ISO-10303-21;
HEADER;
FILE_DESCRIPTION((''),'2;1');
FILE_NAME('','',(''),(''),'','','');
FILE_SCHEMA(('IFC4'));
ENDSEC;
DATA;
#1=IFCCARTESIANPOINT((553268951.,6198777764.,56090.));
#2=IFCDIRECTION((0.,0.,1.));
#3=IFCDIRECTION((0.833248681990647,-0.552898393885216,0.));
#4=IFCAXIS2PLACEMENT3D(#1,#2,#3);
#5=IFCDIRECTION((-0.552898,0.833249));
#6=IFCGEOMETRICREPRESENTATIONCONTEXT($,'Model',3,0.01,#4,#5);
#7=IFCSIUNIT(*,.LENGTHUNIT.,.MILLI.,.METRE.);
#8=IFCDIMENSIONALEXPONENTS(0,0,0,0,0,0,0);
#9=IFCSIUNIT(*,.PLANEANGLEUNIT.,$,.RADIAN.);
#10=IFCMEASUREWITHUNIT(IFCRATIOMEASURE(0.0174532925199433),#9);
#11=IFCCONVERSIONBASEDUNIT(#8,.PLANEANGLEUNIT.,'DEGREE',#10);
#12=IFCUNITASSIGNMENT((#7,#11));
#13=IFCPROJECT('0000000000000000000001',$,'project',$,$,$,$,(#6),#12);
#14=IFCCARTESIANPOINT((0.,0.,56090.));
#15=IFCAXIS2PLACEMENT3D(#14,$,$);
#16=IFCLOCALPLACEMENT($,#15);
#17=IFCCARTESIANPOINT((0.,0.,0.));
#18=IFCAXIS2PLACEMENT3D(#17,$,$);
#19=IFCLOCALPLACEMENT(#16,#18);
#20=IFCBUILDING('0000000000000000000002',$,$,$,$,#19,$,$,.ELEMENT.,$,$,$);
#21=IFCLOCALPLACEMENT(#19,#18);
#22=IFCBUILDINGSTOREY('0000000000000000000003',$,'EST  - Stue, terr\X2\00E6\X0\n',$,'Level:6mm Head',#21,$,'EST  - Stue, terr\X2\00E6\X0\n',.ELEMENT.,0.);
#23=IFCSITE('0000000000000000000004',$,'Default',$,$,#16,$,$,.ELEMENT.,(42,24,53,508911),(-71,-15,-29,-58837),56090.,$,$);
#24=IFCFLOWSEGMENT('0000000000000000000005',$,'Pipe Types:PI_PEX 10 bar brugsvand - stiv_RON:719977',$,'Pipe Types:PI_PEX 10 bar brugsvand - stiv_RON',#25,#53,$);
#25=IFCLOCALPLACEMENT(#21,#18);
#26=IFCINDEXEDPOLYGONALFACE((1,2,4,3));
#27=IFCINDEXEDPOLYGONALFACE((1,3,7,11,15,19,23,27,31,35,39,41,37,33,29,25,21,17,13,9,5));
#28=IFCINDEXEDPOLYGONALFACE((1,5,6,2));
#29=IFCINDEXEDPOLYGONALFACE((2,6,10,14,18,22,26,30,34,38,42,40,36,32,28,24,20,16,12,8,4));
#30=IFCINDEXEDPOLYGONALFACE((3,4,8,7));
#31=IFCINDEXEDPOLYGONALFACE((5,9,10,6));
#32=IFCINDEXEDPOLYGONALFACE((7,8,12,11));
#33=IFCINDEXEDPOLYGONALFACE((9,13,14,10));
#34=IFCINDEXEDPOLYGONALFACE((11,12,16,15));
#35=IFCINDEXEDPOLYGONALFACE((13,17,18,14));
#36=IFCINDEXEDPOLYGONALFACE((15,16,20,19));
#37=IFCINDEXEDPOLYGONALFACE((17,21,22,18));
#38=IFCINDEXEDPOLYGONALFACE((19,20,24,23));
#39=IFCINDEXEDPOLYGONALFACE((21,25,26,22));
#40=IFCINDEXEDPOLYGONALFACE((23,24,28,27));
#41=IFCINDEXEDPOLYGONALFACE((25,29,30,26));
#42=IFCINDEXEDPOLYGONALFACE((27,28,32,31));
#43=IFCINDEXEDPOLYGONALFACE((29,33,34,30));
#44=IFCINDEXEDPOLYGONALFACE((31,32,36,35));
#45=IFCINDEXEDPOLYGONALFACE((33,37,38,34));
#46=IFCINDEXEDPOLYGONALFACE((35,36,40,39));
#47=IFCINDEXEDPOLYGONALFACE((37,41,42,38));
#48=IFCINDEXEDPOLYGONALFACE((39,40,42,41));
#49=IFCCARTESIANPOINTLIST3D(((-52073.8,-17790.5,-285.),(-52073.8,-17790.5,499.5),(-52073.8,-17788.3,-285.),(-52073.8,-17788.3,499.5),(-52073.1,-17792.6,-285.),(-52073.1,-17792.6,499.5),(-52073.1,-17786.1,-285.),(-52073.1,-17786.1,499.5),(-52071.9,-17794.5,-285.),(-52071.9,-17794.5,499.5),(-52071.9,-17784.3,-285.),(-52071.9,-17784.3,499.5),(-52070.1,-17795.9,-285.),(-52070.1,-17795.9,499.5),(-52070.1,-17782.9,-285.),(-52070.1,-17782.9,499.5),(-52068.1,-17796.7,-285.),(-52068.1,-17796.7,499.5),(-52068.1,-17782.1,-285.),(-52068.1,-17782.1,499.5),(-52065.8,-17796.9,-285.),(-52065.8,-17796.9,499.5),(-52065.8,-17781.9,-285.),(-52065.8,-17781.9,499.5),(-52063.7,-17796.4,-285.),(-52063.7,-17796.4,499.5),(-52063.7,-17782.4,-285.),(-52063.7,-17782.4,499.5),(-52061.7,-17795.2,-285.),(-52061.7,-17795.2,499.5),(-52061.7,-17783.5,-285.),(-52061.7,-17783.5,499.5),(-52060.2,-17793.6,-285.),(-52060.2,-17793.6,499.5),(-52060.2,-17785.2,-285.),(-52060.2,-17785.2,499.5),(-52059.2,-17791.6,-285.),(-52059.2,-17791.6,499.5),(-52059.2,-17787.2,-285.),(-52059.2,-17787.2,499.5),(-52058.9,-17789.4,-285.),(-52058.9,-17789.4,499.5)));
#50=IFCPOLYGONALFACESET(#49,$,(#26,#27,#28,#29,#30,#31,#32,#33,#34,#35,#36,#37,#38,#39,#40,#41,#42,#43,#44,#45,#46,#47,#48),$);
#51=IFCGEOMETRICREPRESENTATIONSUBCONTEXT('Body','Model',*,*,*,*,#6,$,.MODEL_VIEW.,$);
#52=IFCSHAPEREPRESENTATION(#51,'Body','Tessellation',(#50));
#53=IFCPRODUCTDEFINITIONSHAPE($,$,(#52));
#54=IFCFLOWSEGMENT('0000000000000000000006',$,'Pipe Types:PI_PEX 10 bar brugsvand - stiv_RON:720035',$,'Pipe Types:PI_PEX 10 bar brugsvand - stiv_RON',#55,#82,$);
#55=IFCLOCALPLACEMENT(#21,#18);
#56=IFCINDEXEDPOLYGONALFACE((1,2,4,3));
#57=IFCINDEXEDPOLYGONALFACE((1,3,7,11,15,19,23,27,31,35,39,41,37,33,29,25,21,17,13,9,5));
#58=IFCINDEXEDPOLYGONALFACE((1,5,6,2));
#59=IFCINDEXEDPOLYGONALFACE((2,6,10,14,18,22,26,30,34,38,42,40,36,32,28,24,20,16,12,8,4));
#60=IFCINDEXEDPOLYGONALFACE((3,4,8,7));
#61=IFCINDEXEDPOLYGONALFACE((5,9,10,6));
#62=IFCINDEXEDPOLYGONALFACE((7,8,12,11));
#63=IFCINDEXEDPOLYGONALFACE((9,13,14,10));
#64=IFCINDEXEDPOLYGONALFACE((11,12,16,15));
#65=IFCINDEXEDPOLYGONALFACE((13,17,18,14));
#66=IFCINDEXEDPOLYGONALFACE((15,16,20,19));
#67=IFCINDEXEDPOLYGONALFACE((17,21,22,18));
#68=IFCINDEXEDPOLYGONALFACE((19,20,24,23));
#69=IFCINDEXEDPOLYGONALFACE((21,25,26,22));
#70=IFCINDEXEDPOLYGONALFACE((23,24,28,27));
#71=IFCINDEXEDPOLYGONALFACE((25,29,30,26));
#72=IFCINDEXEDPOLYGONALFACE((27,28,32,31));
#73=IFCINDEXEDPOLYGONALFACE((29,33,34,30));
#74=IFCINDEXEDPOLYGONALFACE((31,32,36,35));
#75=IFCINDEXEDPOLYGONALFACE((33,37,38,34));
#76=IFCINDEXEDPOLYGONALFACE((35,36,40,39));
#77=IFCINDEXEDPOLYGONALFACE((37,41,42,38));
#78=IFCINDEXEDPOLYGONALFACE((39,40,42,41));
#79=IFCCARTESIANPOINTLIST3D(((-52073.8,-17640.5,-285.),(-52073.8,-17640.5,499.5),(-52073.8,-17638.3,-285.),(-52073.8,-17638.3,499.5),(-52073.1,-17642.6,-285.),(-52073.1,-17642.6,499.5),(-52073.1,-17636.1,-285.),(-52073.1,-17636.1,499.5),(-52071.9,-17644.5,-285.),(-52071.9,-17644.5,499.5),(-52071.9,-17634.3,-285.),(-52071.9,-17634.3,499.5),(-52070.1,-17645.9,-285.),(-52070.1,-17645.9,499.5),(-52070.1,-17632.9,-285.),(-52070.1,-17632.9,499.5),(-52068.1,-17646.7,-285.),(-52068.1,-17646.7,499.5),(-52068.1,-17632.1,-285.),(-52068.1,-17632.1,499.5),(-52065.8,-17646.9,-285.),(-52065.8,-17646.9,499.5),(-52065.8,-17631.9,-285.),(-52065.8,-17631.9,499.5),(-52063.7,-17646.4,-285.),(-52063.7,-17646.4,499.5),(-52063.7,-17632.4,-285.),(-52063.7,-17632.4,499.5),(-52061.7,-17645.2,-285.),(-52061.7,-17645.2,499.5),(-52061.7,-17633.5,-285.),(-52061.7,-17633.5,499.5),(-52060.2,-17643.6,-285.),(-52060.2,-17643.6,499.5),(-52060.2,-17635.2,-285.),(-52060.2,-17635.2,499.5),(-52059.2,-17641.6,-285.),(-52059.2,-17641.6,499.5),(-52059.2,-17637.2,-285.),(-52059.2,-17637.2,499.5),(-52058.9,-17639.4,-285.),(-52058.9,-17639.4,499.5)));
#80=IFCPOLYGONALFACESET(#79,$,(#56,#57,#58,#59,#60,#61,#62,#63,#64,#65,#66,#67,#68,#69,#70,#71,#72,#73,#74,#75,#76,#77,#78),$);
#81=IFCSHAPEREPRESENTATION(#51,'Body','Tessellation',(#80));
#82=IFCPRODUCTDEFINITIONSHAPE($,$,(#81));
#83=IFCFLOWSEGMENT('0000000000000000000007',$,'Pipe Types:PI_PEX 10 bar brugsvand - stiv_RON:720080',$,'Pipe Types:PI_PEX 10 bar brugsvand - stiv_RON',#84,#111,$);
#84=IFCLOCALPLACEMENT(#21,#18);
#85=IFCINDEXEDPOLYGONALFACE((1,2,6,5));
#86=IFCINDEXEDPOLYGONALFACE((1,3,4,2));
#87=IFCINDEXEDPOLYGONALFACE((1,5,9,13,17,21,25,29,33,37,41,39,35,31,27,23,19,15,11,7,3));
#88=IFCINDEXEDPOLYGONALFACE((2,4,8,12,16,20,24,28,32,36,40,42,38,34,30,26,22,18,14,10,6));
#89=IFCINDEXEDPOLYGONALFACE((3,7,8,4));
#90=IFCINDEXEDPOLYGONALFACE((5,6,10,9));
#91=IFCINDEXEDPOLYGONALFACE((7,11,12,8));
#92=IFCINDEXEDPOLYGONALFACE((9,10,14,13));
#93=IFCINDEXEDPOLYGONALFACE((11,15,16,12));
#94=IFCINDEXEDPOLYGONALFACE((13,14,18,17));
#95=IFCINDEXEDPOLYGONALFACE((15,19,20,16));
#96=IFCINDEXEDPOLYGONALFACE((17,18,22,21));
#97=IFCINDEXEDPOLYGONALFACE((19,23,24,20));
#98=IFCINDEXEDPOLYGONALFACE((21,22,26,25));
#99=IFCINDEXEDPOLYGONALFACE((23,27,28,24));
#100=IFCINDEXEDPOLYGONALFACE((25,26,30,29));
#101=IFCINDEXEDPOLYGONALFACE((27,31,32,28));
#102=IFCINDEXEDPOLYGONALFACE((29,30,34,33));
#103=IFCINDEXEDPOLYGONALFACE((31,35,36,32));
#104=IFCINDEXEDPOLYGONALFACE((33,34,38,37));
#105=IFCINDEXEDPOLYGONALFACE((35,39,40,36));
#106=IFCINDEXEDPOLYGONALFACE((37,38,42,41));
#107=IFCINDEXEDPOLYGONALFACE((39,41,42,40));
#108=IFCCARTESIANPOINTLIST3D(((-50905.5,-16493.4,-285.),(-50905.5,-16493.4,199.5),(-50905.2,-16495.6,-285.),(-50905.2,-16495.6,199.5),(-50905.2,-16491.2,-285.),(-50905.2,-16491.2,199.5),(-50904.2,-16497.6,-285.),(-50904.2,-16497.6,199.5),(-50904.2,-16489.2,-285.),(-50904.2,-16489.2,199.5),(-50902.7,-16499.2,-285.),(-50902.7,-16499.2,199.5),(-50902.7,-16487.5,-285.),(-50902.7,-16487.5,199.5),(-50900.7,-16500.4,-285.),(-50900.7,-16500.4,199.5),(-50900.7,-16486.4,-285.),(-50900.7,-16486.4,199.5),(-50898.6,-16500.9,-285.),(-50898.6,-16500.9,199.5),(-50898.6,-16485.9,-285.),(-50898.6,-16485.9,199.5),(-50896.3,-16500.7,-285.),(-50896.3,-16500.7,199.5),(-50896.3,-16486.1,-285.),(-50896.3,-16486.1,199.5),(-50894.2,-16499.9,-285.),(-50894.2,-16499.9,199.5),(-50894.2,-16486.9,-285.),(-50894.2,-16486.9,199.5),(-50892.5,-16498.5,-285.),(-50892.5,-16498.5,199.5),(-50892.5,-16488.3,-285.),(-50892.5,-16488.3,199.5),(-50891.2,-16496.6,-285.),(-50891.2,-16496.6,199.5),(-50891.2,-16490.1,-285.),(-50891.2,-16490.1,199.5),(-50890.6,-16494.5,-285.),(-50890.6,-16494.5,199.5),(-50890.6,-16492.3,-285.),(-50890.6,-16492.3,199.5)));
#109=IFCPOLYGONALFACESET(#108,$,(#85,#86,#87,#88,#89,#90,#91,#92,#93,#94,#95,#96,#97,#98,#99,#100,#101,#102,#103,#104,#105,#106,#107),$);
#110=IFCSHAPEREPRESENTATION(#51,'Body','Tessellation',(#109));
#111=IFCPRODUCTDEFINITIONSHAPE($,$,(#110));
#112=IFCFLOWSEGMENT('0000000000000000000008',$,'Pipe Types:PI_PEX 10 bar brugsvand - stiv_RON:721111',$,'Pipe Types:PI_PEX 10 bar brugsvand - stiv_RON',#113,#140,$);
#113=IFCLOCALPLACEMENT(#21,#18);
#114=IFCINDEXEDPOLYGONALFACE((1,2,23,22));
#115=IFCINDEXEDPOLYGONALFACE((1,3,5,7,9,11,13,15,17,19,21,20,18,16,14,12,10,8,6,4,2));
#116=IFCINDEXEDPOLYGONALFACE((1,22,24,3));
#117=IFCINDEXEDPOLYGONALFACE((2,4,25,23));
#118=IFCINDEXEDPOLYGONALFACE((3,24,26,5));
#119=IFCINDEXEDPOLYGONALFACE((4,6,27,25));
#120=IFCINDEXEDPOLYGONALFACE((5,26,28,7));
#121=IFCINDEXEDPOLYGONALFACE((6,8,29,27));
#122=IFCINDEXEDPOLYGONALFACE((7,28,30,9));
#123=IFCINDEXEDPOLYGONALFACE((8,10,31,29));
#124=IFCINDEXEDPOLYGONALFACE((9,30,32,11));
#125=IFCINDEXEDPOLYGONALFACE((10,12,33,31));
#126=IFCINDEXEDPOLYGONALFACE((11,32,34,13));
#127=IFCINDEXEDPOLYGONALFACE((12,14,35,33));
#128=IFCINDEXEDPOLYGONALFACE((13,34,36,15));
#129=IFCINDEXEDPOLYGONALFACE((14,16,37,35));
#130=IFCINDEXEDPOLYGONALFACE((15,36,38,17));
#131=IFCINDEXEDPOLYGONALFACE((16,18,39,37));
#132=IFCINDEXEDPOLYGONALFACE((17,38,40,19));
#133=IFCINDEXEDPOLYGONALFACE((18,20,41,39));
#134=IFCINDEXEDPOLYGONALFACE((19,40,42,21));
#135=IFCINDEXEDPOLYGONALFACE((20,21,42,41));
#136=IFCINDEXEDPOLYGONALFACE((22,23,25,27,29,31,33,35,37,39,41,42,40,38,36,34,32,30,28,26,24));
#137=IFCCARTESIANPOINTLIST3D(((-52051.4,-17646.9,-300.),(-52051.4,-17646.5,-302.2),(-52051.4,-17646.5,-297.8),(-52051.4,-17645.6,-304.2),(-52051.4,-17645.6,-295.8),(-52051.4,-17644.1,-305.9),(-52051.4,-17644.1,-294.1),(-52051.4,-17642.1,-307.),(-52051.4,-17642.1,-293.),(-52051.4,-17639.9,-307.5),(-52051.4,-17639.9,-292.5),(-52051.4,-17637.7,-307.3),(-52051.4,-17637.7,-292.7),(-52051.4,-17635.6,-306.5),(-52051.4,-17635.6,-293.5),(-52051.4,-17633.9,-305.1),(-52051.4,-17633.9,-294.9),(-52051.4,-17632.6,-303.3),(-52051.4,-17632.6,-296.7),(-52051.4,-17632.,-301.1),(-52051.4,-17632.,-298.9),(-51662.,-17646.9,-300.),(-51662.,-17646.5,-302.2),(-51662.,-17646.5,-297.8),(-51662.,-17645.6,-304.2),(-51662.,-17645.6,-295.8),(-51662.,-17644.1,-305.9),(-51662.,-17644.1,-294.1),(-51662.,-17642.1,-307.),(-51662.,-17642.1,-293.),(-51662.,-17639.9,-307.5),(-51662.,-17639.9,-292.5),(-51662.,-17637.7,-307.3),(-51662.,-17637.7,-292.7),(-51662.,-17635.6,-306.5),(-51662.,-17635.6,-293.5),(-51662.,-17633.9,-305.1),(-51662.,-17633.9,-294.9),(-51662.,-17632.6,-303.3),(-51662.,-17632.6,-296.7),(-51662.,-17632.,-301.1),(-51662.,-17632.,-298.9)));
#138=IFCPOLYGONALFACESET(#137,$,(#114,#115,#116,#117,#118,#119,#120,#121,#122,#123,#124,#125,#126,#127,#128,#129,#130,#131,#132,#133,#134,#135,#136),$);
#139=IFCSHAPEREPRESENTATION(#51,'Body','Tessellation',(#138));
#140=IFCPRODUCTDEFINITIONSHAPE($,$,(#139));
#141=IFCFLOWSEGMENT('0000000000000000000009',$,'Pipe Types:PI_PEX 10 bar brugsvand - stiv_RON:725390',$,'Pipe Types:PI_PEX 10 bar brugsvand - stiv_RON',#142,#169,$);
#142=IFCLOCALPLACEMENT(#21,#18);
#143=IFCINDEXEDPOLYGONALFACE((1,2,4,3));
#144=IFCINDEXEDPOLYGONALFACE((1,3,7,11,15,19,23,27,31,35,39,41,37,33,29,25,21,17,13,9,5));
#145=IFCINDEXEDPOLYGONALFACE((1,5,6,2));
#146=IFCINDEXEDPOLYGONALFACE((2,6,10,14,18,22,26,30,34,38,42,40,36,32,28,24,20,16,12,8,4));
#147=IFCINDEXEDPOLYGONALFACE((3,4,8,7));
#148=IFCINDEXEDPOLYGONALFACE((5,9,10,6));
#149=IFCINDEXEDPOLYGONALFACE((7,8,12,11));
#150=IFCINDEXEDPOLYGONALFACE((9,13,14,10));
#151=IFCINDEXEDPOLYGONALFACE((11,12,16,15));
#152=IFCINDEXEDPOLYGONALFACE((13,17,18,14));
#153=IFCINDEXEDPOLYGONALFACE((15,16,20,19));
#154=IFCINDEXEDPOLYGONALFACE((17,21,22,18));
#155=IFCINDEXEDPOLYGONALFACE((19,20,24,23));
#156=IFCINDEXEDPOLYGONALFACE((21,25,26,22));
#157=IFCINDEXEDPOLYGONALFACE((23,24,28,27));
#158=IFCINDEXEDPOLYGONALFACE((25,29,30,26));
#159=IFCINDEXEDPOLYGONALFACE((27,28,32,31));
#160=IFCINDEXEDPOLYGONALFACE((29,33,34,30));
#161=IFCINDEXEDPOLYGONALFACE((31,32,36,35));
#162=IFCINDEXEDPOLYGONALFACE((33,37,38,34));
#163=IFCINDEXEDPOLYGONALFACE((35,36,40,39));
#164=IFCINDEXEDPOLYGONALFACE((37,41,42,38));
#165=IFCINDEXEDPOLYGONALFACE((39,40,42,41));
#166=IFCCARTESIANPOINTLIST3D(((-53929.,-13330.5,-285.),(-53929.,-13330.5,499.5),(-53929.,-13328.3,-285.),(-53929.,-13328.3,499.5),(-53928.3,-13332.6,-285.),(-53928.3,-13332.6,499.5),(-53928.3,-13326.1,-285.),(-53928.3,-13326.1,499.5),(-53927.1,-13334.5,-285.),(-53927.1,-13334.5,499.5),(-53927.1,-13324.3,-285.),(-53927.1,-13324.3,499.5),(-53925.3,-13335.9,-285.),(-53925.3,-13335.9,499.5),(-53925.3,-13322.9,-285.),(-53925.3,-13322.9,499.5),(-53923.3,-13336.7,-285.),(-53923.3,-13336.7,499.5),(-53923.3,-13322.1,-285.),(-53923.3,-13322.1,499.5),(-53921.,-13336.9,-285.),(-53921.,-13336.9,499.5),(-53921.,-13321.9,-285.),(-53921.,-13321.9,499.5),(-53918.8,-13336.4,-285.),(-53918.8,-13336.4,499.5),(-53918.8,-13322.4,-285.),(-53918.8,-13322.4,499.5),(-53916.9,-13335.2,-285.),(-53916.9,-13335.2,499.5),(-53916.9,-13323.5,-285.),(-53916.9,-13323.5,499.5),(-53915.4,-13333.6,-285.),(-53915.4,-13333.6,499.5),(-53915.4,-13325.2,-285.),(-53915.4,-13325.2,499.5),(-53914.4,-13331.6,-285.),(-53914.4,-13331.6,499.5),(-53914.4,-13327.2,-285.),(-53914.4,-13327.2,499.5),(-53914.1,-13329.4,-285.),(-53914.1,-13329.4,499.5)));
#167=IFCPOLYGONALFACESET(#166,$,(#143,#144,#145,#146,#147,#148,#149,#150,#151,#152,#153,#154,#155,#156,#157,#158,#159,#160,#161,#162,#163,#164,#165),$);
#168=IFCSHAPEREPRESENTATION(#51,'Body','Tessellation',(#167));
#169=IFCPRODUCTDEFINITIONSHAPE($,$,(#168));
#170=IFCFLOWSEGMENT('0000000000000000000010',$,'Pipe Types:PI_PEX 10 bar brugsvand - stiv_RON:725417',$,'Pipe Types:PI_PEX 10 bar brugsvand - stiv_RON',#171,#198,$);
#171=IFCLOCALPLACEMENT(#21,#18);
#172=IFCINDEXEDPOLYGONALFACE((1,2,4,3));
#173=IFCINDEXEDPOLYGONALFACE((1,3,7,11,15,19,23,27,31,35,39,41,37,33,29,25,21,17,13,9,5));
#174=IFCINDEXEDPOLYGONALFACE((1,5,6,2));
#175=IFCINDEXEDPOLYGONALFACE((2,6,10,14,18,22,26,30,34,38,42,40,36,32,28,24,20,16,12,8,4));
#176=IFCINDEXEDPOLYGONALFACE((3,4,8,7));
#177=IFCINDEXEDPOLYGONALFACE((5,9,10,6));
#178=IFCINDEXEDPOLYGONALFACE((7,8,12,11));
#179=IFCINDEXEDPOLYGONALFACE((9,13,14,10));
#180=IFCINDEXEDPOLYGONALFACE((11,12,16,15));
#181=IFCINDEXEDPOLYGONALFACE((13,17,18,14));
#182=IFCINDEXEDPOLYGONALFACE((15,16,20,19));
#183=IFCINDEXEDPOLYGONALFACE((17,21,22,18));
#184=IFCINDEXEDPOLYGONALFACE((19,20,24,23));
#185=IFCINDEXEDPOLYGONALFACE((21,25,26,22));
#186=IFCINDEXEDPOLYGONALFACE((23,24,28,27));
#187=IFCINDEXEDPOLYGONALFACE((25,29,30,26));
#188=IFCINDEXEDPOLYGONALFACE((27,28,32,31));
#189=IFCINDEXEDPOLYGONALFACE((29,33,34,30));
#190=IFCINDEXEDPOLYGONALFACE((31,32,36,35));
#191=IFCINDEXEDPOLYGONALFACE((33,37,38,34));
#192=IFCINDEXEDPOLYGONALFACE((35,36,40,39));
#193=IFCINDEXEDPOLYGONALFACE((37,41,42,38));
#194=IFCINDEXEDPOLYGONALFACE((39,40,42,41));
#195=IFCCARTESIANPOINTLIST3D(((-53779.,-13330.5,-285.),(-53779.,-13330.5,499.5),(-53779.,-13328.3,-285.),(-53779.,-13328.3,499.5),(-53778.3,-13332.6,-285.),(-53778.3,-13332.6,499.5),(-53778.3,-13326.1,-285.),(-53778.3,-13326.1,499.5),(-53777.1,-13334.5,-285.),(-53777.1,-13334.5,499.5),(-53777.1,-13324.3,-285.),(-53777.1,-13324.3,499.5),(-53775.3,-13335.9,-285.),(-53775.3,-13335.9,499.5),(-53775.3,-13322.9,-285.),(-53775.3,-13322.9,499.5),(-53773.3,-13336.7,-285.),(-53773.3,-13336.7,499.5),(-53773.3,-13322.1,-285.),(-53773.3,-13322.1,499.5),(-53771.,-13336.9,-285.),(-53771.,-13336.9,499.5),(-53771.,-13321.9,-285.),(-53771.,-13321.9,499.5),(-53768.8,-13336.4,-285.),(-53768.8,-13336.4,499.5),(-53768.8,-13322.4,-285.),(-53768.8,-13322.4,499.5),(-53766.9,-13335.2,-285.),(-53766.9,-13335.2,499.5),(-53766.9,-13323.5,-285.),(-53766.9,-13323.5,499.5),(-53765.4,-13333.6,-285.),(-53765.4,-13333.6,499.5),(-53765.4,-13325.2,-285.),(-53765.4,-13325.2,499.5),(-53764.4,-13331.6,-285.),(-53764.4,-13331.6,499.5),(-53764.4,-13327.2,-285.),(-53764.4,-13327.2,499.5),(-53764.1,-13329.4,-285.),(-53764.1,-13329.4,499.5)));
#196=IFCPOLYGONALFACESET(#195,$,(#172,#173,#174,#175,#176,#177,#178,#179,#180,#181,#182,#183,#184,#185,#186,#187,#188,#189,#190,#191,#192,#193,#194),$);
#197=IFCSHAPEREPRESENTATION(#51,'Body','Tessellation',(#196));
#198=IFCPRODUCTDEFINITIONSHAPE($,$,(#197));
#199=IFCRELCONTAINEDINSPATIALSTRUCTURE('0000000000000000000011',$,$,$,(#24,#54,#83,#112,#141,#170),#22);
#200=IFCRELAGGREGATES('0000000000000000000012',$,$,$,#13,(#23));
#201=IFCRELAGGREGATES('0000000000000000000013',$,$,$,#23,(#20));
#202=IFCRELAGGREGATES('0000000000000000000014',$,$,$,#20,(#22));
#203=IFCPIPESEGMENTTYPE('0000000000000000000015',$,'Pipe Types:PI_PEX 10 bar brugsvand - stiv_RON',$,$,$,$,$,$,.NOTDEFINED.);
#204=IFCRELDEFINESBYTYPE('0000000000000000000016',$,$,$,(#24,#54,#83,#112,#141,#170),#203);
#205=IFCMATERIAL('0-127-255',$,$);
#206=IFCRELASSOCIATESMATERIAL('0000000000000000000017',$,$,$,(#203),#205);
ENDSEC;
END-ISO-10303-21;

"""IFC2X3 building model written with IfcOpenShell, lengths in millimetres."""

from ifc_helpers import new_model, entity, si_unit, converted_unit, direction, frame, frame_2d, origin, origin_2d_with_axis, place, context, subcontext, project, spatial, circle, extrude, material, type_object, element, save


model = new_model("IFC2X3")

# Units and contexts
model_context = context("Model", 3, precision=0.01, world=frame((553268951.0, 6198777764.0, 56090.0), z_axis=(0.0, 0.0, 1.0), x_axis=(0.833248681990647, -0.552898393885216, 0.0)), true_north=direction((-0.552898, 0.833249)))
body_context = subcontext(model_context, "Body", "Model", "MODEL_VIEW")
ifc_project = project(units=[si_unit("LENGTHUNIT", "METRE", prefix="MILLI"), converted_unit("PLANEANGLEUNIT", "DEGREE", entity("IfcRatioMeasure", 0.0174532925199433), si_unit("PLANEANGLEUNIT", "RADIAN"), dimensions=[0, 0, 0, 0, 0, 0, 0])], contexts=[model_context])

# Site, building, storey
site_placement = place(None, frame((0.0, 0.0, 56090.0)))
site = spatial("IfcSite", under=ifc_project, at=site_placement, Name="Default", CompositionType="ELEMENT", RefLatitude=(42, 24, 53, 508911), RefLongitude=(-71, -15, -29, -58837), RefElevation=56090.0)
building_placement = place(site_placement, origin())
building = spatial("IfcBuilding", under=site, at=building_placement, CompositionType="ELEMENT")
storey_placement = place(building_placement, frame((0.0, 0.0, 0.0)))
storey = spatial("IfcBuildingStorey", under=building, at=storey_placement, Name="EST  - Stue, terræn", ObjectType="Level:6mm Head", LongName="EST  - Stue, terræn", CompositionType="ELEMENT", Elevation=0.0)

# Flow segments
ifc_material_1 = material(Name="0-127-255")
pipe_segment_type_1 = type_object("IfcPipeSegmentType", Name="Pipe Types:PI_PEX 10 bar brugsvand - stiv_RON", PredefinedType="NOTDEFINED", material=ifc_material_1)
flow_segment_1_placement = place(storey_placement, origin())
element("IfcFlowSegment", 1, at=flow_segment_1_placement, inside=storey, type_object=pipe_segment_type_1, Name="Pipe Types:PI_PEX 10 bar brugsvand - stiv_RON:719977", ObjectType="Pipe Types:PI_PEX 10 bar brugsvand - stiv_RON", context=body_context, shape_type="SweptSolid", body=[
    extrude(circle(Radius=7.5, at=frame_2d((0.0, 0.0), x_axis=(1.0, 0.0))), frame((-52066.4, -17789.4, -285.0)), (0.0, 0.0, 1.0), 784.5),
])
flow_segment_2_placement = place(storey_placement, origin())
element("IfcFlowSegment", 2, at=flow_segment_2_placement, inside=storey, type_object=pipe_segment_type_1, Name="Pipe Types:PI_PEX 10 bar brugsvand - stiv_RON:720035", ObjectType="Pipe Types:PI_PEX 10 bar brugsvand - stiv_RON", context=body_context, shape_type="SweptSolid", body=[
    extrude(circle(Radius=7.5, at=origin_2d_with_axis()), frame((-52066.4, -17639.4, -285.0)), (0.0, 0.0, 1.0), 784.5),
])
flow_segment_3_placement = place(storey_placement, origin())
element("IfcFlowSegment", 3, at=flow_segment_3_placement, inside=storey, type_object=pipe_segment_type_1, Name="Pipe Types:PI_PEX 10 bar brugsvand - stiv_RON:720080", ObjectType="Pipe Types:PI_PEX 10 bar brugsvand - stiv_RON", context=body_context, shape_type="SweptSolid", body=[
    extrude(circle(Radius=7.5, at=origin_2d_with_axis()), frame((-50898.0, -16493.4, -285.0), z_axis=(0.0, 0.0, 1.0), x_axis=(-1.0, 0.0, 0.0)), (0.0, 0.0, 1.0), 484.5),
])
flow_segment_4_placement = place(storey_placement, origin())
element("IfcFlowSegment", 4, at=flow_segment_4_placement, inside=storey, type_object=pipe_segment_type_1, Name="Pipe Types:PI_PEX 10 bar brugsvand - stiv_RON:721111", ObjectType="Pipe Types:PI_PEX 10 bar brugsvand - stiv_RON", context=body_context, shape_type="SweptSolid", body=[
    extrude(circle(Radius=7.5, at=origin_2d_with_axis()), frame((-52051.4, -17639.4, -300.0), z_axis=(1.0, 0.0, 0.0), x_axis=(0.0, -1.0, 0.0)), (0.0, 0.0, 1.0), 389.4),
])
flow_segment_5_placement = place(storey_placement, origin())
element("IfcFlowSegment", 5, at=flow_segment_5_placement, inside=storey, type_object=pipe_segment_type_1, Name="Pipe Types:PI_PEX 10 bar brugsvand - stiv_RON:725390", ObjectType="Pipe Types:PI_PEX 10 bar brugsvand - stiv_RON", context=body_context, shape_type="SweptSolid", body=[
    extrude(circle(Radius=7.5, at=frame_2d((0.0, 0.0), x_axis=(1.0, 0.0))), frame((-53921.6, -13329.4, -285.0)), (0.0, 0.0, 1.0), 784.5),
])
flow_segment_6_placement = place(storey_placement, origin())
element("IfcFlowSegment", 6, at=flow_segment_6_placement, inside=storey, type_object=pipe_segment_type_1, Name="Pipe Types:PI_PEX 10 bar brugsvand - stiv_RON:725417", ObjectType="Pipe Types:PI_PEX 10 bar brugsvand - stiv_RON", context=body_context, shape_type="SweptSolid", body=[
    extrude(circle(Radius=7.5, at=origin_2d_with_axis()), frame((-53771.6, -13329.4, -285.0)), (0.0, 0.0, 1.0), 784.5),
])

save(model, "model.ifc")
